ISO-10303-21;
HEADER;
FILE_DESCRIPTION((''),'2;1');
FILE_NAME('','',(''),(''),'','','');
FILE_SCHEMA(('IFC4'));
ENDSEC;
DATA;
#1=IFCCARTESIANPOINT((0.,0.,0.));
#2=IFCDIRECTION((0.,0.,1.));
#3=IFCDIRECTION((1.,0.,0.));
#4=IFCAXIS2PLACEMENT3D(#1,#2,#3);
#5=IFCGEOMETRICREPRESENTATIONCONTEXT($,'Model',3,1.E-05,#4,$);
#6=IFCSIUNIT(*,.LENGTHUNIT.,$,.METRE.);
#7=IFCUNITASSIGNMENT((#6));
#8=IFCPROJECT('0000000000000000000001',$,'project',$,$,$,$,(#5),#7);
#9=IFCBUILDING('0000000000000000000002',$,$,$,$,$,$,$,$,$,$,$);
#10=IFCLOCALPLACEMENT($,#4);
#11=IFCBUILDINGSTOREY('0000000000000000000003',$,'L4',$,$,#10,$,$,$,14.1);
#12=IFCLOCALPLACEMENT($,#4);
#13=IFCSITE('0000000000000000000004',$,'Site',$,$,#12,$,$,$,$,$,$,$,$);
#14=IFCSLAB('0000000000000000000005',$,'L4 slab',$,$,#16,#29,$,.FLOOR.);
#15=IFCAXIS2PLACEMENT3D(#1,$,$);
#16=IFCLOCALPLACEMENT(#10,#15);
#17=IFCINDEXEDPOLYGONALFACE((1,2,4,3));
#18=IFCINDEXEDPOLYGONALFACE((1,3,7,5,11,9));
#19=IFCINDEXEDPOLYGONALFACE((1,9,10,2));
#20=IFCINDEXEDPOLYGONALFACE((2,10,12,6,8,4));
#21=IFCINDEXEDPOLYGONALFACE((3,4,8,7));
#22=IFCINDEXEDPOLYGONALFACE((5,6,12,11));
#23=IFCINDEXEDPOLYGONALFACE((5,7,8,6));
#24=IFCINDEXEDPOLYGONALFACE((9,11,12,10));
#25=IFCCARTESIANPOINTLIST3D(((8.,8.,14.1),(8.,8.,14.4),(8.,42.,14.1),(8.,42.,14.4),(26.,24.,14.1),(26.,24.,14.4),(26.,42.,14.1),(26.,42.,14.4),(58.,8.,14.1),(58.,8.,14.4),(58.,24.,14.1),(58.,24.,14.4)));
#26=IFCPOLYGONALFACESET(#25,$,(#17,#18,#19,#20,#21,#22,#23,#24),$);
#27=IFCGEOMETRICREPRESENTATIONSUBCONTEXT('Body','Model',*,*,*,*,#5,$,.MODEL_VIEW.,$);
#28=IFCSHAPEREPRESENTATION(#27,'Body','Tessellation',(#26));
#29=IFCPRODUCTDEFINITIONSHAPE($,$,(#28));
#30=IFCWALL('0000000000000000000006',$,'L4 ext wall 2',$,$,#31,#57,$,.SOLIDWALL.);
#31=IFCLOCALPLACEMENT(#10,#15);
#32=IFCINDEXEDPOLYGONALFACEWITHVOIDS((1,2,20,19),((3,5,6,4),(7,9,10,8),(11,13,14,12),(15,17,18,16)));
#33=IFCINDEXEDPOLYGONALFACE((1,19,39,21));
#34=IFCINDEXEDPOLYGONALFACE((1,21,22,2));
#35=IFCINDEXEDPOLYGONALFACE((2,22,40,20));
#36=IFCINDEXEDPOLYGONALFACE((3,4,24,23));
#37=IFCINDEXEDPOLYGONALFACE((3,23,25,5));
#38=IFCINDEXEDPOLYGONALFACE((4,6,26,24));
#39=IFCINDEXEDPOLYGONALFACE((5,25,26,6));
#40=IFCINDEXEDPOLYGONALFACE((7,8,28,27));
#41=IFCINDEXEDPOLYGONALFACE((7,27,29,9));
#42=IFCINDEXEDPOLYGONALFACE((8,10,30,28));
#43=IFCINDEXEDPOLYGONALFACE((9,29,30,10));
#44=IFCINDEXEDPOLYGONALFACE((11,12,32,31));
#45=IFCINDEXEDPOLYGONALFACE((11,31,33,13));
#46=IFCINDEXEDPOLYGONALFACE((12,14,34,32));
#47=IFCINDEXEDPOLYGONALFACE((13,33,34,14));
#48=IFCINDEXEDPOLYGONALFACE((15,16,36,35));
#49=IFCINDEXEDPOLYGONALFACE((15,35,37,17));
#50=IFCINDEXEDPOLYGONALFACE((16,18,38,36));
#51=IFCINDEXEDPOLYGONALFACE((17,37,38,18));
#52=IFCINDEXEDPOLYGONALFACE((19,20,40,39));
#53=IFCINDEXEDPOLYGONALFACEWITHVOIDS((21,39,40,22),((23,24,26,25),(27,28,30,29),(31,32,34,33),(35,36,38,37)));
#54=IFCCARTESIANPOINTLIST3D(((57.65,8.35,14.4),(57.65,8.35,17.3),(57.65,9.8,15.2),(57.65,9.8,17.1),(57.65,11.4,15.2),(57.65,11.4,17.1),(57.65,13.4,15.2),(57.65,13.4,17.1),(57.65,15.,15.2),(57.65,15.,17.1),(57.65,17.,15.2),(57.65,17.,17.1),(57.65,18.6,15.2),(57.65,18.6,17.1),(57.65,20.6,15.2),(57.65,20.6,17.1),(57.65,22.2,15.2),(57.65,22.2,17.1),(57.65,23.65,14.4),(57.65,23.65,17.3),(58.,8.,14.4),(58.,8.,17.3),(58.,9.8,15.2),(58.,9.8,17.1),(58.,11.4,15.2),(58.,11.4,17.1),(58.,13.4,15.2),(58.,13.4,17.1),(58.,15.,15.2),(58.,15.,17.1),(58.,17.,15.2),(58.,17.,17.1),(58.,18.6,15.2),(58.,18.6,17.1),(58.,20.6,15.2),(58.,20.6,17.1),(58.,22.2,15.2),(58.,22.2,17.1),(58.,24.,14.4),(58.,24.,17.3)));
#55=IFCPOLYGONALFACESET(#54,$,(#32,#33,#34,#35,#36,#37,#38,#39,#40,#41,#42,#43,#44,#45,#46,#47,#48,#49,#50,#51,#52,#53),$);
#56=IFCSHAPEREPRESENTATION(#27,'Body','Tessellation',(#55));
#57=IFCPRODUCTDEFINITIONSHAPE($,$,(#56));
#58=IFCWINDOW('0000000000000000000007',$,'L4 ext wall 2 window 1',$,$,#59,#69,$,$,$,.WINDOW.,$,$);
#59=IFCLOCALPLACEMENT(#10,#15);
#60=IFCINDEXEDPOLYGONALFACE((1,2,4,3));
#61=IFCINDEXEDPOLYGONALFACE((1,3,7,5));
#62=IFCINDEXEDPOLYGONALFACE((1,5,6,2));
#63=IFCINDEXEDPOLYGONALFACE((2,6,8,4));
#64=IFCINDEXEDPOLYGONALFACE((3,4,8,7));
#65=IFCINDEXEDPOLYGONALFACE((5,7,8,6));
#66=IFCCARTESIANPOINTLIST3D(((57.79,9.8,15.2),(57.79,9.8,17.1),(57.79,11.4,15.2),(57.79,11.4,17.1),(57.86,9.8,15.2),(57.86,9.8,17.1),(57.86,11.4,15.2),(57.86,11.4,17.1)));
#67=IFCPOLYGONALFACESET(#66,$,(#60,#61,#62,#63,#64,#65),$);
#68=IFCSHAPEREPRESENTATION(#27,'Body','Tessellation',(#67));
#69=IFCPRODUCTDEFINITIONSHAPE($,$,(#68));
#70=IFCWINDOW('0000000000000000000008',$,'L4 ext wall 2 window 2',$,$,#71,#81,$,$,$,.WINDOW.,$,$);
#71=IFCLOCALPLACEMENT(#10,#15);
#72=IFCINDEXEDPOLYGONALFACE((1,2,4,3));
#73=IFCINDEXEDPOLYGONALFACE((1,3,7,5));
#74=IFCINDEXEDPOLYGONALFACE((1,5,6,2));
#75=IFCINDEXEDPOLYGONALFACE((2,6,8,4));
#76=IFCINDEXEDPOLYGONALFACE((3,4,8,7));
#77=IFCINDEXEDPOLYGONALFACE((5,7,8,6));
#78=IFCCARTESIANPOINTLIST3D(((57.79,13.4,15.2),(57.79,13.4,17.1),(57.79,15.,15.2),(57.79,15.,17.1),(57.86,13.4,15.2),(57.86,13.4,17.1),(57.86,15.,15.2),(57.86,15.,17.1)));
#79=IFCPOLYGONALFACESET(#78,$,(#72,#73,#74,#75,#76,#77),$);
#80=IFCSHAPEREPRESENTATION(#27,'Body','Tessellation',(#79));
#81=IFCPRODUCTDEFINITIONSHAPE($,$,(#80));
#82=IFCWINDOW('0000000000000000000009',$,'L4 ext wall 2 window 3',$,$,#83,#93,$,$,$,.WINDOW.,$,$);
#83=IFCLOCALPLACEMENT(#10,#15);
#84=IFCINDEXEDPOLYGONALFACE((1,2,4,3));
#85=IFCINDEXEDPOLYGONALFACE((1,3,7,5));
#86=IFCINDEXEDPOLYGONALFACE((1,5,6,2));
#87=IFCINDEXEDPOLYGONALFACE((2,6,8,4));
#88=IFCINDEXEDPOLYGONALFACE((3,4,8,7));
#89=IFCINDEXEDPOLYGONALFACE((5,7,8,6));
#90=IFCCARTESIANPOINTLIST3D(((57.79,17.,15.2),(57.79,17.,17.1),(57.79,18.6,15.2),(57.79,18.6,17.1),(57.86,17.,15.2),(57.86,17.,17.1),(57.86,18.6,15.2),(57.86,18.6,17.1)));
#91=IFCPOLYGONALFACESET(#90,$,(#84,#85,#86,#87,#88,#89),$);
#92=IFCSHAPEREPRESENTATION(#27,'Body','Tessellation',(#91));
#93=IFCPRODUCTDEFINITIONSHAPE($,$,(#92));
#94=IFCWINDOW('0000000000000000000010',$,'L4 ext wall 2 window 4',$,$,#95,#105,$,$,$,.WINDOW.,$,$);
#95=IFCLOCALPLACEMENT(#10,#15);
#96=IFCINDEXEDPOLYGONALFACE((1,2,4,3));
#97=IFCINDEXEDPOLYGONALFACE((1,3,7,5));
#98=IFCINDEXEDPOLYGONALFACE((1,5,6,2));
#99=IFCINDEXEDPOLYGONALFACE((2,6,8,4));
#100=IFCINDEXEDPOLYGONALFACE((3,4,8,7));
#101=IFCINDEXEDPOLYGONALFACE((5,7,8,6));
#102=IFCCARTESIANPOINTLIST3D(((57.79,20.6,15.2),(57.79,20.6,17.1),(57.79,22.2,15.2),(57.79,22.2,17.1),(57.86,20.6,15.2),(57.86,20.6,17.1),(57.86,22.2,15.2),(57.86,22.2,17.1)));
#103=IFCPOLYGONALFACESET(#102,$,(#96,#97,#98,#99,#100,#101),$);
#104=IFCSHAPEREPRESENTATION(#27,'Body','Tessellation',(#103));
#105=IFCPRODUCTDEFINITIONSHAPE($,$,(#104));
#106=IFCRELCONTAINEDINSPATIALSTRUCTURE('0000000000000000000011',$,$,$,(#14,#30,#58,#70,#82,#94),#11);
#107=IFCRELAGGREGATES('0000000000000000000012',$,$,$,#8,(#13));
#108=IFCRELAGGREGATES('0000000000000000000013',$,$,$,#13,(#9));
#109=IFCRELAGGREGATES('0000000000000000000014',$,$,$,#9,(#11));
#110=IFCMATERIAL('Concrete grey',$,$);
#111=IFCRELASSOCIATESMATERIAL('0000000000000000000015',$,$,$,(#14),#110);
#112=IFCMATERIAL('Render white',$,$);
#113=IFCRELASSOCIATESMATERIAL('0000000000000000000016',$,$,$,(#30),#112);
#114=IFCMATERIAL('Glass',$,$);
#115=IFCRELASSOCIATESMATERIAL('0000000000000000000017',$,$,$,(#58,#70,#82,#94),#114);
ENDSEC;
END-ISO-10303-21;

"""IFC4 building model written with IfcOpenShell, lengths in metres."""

from ifc_helpers import new_model, si_unit, frame, origin_with_axes, place, context, subcontext, project, spatial, polyline, outline, extrude, material, element, fill, save


model = new_model("IFC4")

# Units and contexts
model_context = context("Model", 3, precision=1e-05, world=origin_with_axes())
body_context = subcontext(model_context, "Body", "Model", "MODEL_VIEW")
ifc_project = project(units=[si_unit("LENGTHUNIT", "METRE")], contexts=[model_context])

# Site, building, storey
site_placement = place(None, origin_with_axes())
site = spatial("IfcSite", under=ifc_project, at=site_placement, Name="Site")
building = spatial("IfcBuilding", under=site)
storey_placement = place(None, origin_with_axes())
storey = spatial("IfcBuildingStorey", under=building, at=storey_placement, Name="L4", Elevation=14.1)

# Slab
ifc_material_1 = material(Name="Concrete grey")
slab_placement = place(storey_placement, origin_with_axes())
element("IfcSlab", 1, at=slab_placement, inside=storey, material=ifc_material_1, Name="L4 slab", PredefinedType="FLOOR", context=body_context, shape_type="SweptSolid", body=[
    extrude(outline(polyline([(8.0, 8.0), (58.0, 8.0), (58.0, 24.0), (26.0, 24.0), (26.0, 42.0), (8.0, 42.0), (8.0, 8.0)])), frame((0.0, 0.0, 14.1), z_axis=(0.0, 0.0, 1.0), x_axis=(1.0, 0.0, 0.0)), (0.0, 0.0, 1.0), 0.3),
])

# Wall, openings, windows
ifc_material_2 = material(Name="Render white")
ifc_material_3 = material(Name="Glass")
wall_1_placement = place(storey_placement, origin_with_axes())
wall_1 = element("IfcWall", 2, at=wall_1_placement, inside=storey, material=ifc_material_2, Name="L4 ext wall 2", PredefinedType="SOLIDWALL", context=body_context, shape_type="SweptSolid", body=[
    extrude(outline(polyline([(58.0, 8.0), (58.0, 24.0), (57.65, 23.65), (57.65, 8.35), (58.0, 8.0)])), frame((0.0, 0.0, 14.4), z_axis=(0.0, 0.0, 1.0), x_axis=(1.0, 0.0, 0.0)), (0.0, 0.0, 1.0), 2.9),
])
opening_1_placement = place(wall_1_placement, origin_with_axes())
opening_1 = element("IfcOpeningElement", 3, at=opening_1_placement, cuts=wall_1, context=body_context, shape_type="SweptSolid", body=[
    extrude(outline(polyline([(58.05, 9.8), (58.05, 11.4), (57.6, 11.4), (57.6, 9.8), (58.05, 9.8)])), frame((0.0, 0.0, 15.2), z_axis=(0.0, 0.0, 1.0), x_axis=(1.0, 0.0, 0.0)), (0.0, 0.0, 1.0), 1.9),
])
opening_2_placement = place(wall_1_placement, origin_with_axes())
opening_2 = element("IfcOpeningElement", 4, at=opening_2_placement, cuts=wall_1, context=body_context, shape_type="SweptSolid", body=[
    extrude(outline(polyline([(58.05, 13.4), (58.05, 15.0), (57.6, 15.0), (57.6, 13.4), (58.05, 13.4)])), frame((0.0, 0.0, 15.2), z_axis=(0.0, 0.0, 1.0), x_axis=(1.0, 0.0, 0.0)), (0.0, 0.0, 1.0), 1.9),
])
opening_3_placement = place(wall_1_placement, origin_with_axes())
opening_3 = element("IfcOpeningElement", 5, at=opening_3_placement, cuts=wall_1, context=body_context, shape_type="SweptSolid", body=[
    extrude(outline(polyline([(58.05, 17.0), (58.05, 18.6), (57.6, 18.6), (57.6, 17.0), (58.05, 17.0)])), frame((0.0, 0.0, 15.2), z_axis=(0.0, 0.0, 1.0), x_axis=(1.0, 0.0, 0.0)), (0.0, 0.0, 1.0), 1.9),
])
opening_4_placement = place(wall_1_placement, origin_with_axes())
opening_4 = element("IfcOpeningElement", 6, at=opening_4_placement, cuts=wall_1, context=body_context, shape_type="SweptSolid", body=[
    extrude(outline(polyline([(58.05, 20.6), (58.05, 22.2), (57.6, 22.2), (57.6, 20.6), (58.05, 20.6)])), frame((0.0, 0.0, 15.2), z_axis=(0.0, 0.0, 1.0), x_axis=(1.0, 0.0, 0.0)), (0.0, 0.0, 1.0), 1.9),
])
window_1_placement = place(storey_placement, origin_with_axes())
window_1 = element("IfcWindow", 7, at=window_1_placement, inside=storey, material=ifc_material_3, Name="L4 ext wall 2 window 1", PredefinedType="WINDOW", context=body_context, shape_type="SweptSolid", body=[
    extrude(outline(polyline([(57.86, 9.8), (57.86, 11.4), (57.79, 11.4), (57.79, 9.8), (57.86, 9.8)])), frame((0.0, 0.0, 15.2), z_axis=(0.0, 0.0, 1.0), x_axis=(1.0, 0.0, 0.0)), (0.0, 0.0, 1.0), 1.9),
])
fill(opening_1, window_1)
window_2_placement = place(storey_placement, origin_with_axes())
window_2 = element("IfcWindow", 8, at=window_2_placement, inside=storey, material=ifc_material_3, Name="L4 ext wall 2 window 2", PredefinedType="WINDOW", context=body_context, shape_type="SweptSolid", body=[
    extrude(outline(polyline([(57.86, 13.4), (57.86, 15.0), (57.79, 15.0), (57.79, 13.4), (57.86, 13.4)])), frame((0.0, 0.0, 15.2), z_axis=(0.0, 0.0, 1.0), x_axis=(1.0, 0.0, 0.0)), (0.0, 0.0, 1.0), 1.9),
])
fill(opening_2, window_2)
window_3_placement = place(storey_placement, origin_with_axes())
window_3 = element("IfcWindow", 9, at=window_3_placement, inside=storey, material=ifc_material_3, Name="L4 ext wall 2 window 3", PredefinedType="WINDOW", context=body_context, shape_type="SweptSolid", body=[
    extrude(outline(polyline([(57.86, 17.0), (57.86, 18.6), (57.79, 18.6), (57.79, 17.0), (57.86, 17.0)])), frame((0.0, 0.0, 15.2), z_axis=(0.0, 0.0, 1.0), x_axis=(1.0, 0.0, 0.0)), (0.0, 0.0, 1.0), 1.9),
])
fill(opening_3, window_3)
window_4_placement = place(storey_placement, origin_with_axes())
window_4 = element("IfcWindow", 10, at=window_4_placement, inside=storey, material=ifc_material_3, Name="L4 ext wall 2 window 4", PredefinedType="WINDOW", context=body_context, shape_type="SweptSolid", body=[
    extrude(outline(polyline([(57.86, 20.6), (57.86, 22.2), (57.79, 22.2), (57.79, 20.6), (57.86, 20.6)])), frame((0.0, 0.0, 15.2), z_axis=(0.0, 0.0, 1.0), x_axis=(1.0, 0.0, 0.0)), (0.0, 0.0, 1.0), 1.9),
])
fill(opening_4, window_4)

save(model, "model.ifc")
